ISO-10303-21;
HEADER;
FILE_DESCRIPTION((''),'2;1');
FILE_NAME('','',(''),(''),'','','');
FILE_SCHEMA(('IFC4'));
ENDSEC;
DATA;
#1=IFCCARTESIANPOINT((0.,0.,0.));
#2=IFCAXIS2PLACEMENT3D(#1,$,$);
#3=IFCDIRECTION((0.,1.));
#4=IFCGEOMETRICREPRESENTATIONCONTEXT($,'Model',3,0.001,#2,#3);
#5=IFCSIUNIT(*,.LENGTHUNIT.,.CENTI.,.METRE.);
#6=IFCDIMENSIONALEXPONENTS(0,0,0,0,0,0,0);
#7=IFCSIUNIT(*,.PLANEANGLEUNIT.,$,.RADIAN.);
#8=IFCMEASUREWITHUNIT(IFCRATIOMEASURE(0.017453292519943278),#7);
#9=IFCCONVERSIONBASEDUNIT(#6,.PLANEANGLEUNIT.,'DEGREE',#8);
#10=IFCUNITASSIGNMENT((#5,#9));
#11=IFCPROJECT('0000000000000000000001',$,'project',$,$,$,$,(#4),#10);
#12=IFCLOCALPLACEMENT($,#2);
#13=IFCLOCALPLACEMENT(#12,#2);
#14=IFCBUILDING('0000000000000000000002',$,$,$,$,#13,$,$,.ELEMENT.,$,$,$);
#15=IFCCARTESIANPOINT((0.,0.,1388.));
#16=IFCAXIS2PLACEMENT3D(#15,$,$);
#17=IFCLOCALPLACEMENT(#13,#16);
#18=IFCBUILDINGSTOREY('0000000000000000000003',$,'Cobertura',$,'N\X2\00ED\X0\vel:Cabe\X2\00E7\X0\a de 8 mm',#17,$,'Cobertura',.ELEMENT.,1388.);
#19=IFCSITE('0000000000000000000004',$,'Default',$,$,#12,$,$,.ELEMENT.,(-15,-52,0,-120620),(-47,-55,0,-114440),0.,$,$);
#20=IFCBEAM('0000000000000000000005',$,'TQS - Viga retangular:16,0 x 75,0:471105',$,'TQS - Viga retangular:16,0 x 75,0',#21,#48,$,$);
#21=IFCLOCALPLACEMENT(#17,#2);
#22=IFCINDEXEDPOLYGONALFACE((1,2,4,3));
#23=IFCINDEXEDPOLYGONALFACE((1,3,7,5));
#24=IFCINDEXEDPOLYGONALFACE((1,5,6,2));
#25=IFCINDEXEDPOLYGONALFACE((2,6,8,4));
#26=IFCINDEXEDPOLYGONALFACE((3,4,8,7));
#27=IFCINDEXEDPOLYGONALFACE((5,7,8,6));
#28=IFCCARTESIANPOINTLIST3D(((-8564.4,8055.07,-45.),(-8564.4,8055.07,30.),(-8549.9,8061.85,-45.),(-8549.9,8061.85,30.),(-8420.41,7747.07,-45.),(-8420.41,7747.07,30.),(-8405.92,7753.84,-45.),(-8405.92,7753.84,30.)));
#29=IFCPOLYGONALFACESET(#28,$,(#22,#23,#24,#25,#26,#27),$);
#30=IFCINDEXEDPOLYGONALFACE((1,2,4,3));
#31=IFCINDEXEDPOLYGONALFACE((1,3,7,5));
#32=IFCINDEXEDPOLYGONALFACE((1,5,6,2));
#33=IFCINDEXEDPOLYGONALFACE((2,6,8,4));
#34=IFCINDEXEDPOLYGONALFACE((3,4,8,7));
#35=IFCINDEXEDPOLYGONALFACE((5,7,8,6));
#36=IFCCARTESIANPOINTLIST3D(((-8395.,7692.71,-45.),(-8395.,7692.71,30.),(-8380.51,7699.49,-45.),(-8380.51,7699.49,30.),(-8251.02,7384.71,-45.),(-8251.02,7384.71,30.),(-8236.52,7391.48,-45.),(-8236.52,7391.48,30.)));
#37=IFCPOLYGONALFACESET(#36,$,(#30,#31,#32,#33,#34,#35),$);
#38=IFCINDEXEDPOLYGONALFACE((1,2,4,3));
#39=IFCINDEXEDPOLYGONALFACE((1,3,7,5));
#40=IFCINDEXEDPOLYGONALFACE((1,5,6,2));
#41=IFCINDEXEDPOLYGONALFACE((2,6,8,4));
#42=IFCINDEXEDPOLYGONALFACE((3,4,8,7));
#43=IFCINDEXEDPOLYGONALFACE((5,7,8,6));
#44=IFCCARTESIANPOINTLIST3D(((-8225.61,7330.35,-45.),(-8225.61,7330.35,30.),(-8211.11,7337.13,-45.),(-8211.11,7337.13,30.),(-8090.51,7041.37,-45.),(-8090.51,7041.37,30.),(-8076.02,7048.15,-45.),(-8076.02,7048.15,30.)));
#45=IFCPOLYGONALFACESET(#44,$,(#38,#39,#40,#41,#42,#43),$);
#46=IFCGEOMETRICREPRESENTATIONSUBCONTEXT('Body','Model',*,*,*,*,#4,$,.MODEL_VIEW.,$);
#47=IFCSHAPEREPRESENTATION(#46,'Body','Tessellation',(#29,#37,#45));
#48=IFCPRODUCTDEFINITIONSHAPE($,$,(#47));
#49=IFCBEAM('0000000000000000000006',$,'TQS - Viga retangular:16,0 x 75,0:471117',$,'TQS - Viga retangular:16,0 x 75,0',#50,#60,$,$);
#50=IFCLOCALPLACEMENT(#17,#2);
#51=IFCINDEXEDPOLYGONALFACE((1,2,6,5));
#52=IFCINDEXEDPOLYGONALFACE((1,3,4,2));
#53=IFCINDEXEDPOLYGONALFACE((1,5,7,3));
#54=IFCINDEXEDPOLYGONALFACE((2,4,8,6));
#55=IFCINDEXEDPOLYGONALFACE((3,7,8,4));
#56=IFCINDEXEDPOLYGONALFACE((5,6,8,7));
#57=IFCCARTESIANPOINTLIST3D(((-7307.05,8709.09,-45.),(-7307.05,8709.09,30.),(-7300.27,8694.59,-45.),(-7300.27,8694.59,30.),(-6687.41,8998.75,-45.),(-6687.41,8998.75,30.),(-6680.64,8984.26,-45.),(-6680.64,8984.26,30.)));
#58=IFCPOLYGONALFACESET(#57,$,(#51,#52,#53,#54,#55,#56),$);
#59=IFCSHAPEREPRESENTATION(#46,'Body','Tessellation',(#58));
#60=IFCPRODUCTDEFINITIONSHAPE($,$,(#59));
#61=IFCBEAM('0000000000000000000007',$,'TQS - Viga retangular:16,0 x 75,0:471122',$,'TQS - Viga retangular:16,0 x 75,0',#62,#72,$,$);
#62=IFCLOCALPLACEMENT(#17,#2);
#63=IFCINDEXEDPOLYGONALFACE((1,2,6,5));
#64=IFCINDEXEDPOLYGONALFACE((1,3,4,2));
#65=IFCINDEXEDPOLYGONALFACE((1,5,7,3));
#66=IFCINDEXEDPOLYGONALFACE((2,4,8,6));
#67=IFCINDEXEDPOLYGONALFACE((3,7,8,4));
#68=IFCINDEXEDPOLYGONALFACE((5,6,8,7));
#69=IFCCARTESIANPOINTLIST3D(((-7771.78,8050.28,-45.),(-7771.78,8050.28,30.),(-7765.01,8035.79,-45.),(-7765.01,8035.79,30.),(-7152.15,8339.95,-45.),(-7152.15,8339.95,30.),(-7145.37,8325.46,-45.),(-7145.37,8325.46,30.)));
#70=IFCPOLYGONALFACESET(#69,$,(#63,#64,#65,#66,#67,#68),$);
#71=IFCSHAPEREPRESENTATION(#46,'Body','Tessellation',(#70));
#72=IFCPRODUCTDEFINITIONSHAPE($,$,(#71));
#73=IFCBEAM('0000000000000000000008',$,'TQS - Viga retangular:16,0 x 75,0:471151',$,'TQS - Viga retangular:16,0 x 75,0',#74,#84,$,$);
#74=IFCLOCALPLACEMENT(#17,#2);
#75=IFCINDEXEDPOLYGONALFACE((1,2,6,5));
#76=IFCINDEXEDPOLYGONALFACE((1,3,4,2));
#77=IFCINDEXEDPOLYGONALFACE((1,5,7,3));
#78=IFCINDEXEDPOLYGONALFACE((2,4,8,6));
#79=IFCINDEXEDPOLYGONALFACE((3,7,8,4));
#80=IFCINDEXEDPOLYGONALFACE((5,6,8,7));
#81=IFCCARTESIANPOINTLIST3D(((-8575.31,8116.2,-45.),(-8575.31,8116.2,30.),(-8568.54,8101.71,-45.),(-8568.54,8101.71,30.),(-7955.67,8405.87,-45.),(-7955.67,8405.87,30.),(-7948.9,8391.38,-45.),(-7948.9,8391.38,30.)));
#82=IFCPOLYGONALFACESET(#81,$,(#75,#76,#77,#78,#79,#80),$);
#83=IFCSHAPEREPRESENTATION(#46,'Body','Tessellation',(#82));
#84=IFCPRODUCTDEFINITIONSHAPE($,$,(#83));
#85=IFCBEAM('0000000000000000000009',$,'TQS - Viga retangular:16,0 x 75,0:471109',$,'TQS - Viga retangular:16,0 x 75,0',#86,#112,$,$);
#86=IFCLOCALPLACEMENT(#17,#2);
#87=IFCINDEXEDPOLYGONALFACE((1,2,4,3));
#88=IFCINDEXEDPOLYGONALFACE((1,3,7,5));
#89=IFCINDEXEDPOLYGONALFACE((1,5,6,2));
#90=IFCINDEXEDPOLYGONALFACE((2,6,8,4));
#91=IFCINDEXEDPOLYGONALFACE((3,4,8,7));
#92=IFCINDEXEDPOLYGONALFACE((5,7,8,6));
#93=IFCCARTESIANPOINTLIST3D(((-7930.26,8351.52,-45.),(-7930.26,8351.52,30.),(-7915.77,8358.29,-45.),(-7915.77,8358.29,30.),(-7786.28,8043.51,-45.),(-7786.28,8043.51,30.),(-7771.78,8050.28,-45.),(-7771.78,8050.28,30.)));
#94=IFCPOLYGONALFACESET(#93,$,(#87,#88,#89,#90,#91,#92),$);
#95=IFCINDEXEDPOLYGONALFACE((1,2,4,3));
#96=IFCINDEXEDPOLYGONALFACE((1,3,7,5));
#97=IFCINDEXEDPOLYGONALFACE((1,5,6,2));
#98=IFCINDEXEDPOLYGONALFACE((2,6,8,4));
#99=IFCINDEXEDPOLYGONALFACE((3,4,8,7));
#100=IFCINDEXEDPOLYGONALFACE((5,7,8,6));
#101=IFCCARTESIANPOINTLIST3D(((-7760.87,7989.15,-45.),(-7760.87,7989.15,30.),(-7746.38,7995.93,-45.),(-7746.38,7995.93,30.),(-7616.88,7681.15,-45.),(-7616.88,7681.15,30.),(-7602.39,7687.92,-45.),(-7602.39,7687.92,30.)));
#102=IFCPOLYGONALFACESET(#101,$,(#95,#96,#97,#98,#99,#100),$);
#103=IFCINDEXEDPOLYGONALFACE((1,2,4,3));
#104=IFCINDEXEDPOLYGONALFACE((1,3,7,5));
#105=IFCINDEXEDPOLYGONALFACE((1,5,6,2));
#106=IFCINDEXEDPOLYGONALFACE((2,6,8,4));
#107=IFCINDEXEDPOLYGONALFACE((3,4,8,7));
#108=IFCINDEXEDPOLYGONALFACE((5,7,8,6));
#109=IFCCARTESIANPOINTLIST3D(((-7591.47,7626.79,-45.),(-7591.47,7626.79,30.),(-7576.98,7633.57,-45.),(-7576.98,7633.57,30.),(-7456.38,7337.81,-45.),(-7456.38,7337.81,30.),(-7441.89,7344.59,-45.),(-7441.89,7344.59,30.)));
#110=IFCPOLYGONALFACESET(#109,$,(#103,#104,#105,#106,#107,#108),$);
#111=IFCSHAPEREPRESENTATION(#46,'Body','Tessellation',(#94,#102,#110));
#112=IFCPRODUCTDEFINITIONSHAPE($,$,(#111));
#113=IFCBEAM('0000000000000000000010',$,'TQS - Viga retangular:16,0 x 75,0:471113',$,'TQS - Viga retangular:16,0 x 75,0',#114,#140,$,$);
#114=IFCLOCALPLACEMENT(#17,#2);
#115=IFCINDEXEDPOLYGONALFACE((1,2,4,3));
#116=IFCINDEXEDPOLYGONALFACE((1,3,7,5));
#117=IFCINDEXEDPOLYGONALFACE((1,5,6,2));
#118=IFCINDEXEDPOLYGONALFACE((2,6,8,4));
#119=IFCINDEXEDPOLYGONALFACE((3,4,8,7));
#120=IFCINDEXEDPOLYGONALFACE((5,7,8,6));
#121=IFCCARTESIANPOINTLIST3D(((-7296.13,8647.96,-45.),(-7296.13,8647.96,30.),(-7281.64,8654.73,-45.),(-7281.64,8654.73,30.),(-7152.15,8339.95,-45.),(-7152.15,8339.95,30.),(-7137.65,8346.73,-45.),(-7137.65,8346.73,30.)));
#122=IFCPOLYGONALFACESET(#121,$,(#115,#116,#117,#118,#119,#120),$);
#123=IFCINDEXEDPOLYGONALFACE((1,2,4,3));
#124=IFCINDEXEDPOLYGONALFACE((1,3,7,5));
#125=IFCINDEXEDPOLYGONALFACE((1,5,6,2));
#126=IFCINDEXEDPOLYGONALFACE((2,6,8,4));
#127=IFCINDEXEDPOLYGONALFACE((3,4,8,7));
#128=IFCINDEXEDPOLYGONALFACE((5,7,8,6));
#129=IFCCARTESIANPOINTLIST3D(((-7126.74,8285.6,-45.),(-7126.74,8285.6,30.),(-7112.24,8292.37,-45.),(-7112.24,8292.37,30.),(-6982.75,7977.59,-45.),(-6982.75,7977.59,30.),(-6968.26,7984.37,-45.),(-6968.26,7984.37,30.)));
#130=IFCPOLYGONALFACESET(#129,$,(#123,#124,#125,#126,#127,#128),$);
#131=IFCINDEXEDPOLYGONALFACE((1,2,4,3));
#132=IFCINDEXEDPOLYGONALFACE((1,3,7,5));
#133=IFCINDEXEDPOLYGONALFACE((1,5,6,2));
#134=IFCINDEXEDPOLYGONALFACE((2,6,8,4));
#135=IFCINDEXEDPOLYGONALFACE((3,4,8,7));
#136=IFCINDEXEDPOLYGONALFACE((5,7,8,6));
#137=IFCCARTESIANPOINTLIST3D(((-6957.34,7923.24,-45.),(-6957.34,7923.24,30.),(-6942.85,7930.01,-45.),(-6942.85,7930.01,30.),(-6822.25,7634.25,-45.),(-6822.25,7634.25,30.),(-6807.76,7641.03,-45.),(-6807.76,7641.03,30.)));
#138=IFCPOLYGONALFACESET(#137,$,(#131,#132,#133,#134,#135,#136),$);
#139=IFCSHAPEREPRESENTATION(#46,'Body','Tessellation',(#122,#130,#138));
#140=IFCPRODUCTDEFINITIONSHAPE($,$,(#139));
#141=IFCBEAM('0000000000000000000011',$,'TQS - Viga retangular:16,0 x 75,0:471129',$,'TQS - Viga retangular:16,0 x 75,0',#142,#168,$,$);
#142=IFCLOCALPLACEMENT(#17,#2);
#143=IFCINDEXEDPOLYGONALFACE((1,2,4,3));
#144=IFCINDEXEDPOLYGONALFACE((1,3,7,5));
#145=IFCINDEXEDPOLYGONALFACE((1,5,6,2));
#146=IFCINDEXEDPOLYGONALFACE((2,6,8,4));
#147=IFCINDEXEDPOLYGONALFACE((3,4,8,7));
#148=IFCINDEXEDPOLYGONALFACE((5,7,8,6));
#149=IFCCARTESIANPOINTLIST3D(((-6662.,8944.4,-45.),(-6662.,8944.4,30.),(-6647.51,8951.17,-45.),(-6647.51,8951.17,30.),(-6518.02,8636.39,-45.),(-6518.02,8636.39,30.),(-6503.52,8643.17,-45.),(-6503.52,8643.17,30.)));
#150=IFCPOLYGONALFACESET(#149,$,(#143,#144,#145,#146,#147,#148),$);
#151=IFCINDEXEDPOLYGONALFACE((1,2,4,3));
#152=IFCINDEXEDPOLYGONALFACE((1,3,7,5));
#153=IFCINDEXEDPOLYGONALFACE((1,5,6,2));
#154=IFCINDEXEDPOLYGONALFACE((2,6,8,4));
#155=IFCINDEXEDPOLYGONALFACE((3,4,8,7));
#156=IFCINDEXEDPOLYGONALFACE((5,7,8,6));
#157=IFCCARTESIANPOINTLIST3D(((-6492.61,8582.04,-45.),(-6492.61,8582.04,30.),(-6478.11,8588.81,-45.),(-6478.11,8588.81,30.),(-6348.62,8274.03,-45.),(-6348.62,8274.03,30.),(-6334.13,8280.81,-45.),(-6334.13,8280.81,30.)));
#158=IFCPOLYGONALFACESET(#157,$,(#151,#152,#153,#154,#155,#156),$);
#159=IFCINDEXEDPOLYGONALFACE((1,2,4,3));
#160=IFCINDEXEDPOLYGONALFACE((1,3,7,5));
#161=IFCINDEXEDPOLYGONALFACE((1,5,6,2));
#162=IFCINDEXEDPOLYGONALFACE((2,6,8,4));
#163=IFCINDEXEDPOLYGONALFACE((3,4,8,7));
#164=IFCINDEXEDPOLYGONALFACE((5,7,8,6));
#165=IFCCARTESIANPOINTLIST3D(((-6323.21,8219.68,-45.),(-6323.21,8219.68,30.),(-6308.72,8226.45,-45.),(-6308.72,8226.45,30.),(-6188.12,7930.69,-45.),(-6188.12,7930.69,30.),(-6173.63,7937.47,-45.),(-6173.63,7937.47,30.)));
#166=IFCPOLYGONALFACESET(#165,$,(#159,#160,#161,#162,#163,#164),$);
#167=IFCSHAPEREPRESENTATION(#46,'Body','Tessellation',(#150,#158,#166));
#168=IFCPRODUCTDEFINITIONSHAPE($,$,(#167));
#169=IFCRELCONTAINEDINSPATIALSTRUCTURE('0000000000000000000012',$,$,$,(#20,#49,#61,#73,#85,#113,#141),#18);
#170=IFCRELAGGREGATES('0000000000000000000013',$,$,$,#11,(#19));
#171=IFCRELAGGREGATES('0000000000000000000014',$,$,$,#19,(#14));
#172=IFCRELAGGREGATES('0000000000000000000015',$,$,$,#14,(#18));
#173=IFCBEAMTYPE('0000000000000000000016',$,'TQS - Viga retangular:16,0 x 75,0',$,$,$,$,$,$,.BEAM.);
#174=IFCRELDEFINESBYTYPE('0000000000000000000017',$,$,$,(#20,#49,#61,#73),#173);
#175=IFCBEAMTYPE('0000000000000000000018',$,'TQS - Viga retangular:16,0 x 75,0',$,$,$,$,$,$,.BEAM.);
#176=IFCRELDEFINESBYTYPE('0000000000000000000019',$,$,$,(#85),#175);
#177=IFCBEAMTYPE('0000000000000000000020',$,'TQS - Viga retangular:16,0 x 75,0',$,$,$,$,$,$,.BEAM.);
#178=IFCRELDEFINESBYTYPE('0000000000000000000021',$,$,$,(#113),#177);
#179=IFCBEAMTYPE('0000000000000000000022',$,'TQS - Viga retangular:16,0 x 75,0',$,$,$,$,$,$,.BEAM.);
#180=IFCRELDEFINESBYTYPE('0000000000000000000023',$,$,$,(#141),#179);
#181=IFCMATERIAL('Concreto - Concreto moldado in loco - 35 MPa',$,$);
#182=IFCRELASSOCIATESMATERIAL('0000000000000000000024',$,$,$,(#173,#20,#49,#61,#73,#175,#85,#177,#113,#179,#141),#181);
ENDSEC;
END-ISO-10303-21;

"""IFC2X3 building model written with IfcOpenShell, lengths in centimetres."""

from ifc_helpers import new_model, entity, si_unit, converted_unit, direction, frame, frame_2d, origin, place, context, subcontext, project, spatial, rectangle, extrude, source, transform, mapped, material, type_object, type_shapes, element, save


model = new_model("IFC2X3")

# Units and contexts
model_context = context("Model", 3, precision=0.001, world=origin(), true_north=direction((0.0, 1.0)))
body_context = subcontext(model_context, "Body", "Model", "MODEL_VIEW")
ifc_project = project(units=[si_unit("LENGTHUNIT", "METRE", prefix="CENTI"), converted_unit("PLANEANGLEUNIT", "DEGREE", entity("IfcRatioMeasure", 0.017453292519943278), si_unit("PLANEANGLEUNIT", "RADIAN"), dimensions=[0, 0, 0, 0, 0, 0, 0])], contexts=[model_context])

# Site, building, storey
site_placement = place(None, origin())
site = spatial("IfcSite", under=ifc_project, at=site_placement, Name="Default", CompositionType="ELEMENT", RefLatitude=(-15, -52, 0, -120620), RefLongitude=(-47, -55, 0, -114440), RefElevation=0.0)
building_placement = place(site_placement, origin())
building = spatial("IfcBuilding", under=site, at=building_placement, CompositionType="ELEMENT")
storey_placement = place(building_placement, frame((0.0, 0.0, 1388.0)))
storey = spatial("IfcBuildingStorey", under=building, at=storey_placement, Name="Cobertura", ObjectType="Nível:Cabeça de 8 mm", LongName="Cobertura", CompositionType="ELEMENT", Elevation=1388.0)

# Beams
ifc_material = material(Name="Concreto - Concreto moldado in loco - 35 MPa")
beam_type_1 = type_object("IfcBeamType", Name="TQS - Viga retangular:16,0 x 75,0", PredefinedType="BEAM", material=ifc_material)
shared_shape_1 = source(origin(), body_context, "Body", "SweptSolid", [
    extrude(rectangle(XDim=75.0, YDim=16.0, at=frame_2d((0.0, 0.0), x_axis=(1.0, 0.0))), frame((-8413.16, 7750.46, 1380.5), z_axis=(-0.423488, 0.905902, 0.0), x_axis=(0.0, 0.0, 1.0)), (0.0, 0.0, 1.0), 340.0),
    extrude(rectangle(XDim=75.0, YDim=16.0, at=frame_2d((0.0, 0.0), x_axis=(1.0, 0.0))), frame((-8243.77, 7388.09, 1380.5), z_axis=(-0.423488, 0.905902, 0.0), x_axis=(0.0, 0.0, 1.0)), (0.0, 0.0, 1.0), 340.0),
    extrude(rectangle(XDim=75.0, YDim=16.0, at=frame_2d((0.0, 0.0), x_axis=(1.0, 0.0))), frame((-8083.27, 7044.76, 1380.5), z_axis=(-0.423488, 0.905902, 0.0), x_axis=(0.0, 0.0, 1.0)), (0.0, 0.0, 1.0), 319.0),
])
type_shapes(beam_type_1, [shared_shape_1])
beam_1_placement = place(storey_placement, frame((0.0, 0.0, -1388.0)))
element("IfcBeam", 1, at=beam_1_placement, inside=storey, type_object=beam_type_1, material=ifc_material, Name="TQS - Viga retangular:16,0 x 75,0:471105", ObjectType="TQS - Viga retangular:16,0 x 75,0", context=body_context, shape_type="MappedRepresentation", body=[
    mapped(shared_shape_1, transform((0.0, 0.0, 0.0), scale=1.0)),
])
beam_2_placement = place(storey_placement, frame((-7310.91, 8698.45, 30.0), z_axis=(0.0, 0.0, 1.0), x_axis=(0.905902, 0.423488, 0.0)))
element("IfcBeam", 2, at=beam_2_placement, inside=storey, type_object=beam_type_1, material=ifc_material, Name="TQS - Viga retangular:16,0 x 75,0:471117", ObjectType="TQS - Viga retangular:16,0 x 75,0", context=body_context, shape_type="SweptSolid", body=[
    extrude(rectangle(XDim=75.0, YDim=16.0, at=frame_2d((0.0, 0.0), x_axis=(1.0, 0.0))), frame((8.0, 0.0, -37.5), z_axis=(1.0, 0.0, 0.0), x_axis=(0.0, 0.0, -1.0)), (0.0, 0.0, 1.0), 684.0),
])
beam_3_placement = place(storey_placement, frame((-7775.64, 8039.65, 30.0), z_axis=(0.0, 0.0, 1.0), x_axis=(0.905902, 0.423488, 0.0)))
element("IfcBeam", 3, at=beam_3_placement, inside=storey, type_object=beam_type_1, material=ifc_material, Name="TQS - Viga retangular:16,0 x 75,0:471122", ObjectType="TQS - Viga retangular:16,0 x 75,0", context=body_context, shape_type="SweptSolid", body=[
    extrude(rectangle(XDim=75.0, YDim=16.0, at=frame_2d((0.0, 0.0), x_axis=(1.0, 0.0))), frame((8.0, 0.0, -37.5), z_axis=(1.0, 0.0, 0.0), x_axis=(0.0, 0.0, -1.0)), (0.0, 0.0, 1.0), 684.0),
])
beam_4_placement = place(storey_placement, frame((-8579.17, 8105.57, 30.0), z_axis=(0.0, 0.0, 1.0), x_axis=(0.905902, 0.423488, 0.0)))
element("IfcBeam", 4, at=beam_4_placement, inside=storey, type_object=beam_type_1, material=ifc_material, Name="TQS - Viga retangular:16,0 x 75,0:471151", ObjectType="TQS - Viga retangular:16,0 x 75,0", context=body_context, shape_type="SweptSolid", body=[
    extrude(rectangle(XDim=75.0, YDim=16.0, at=frame_2d((0.0, 0.0), x_axis=(1.0, 0.0))), frame((8.0, 0.0, -37.5), z_axis=(1.0, 0.0, 0.0), x_axis=(0.0, 0.0, -1.0)), (0.0, 0.0, 1.0), 684.0),
])
beam_type_2 = type_object("IfcBeamType", Name="TQS - Viga retangular:16,0 x 75,0", PredefinedType="BEAM", material=ifc_material)
shared_shape_2 = source(origin(), body_context, "Body", "SweptSolid", [
    extrude(rectangle(XDim=75.0, YDim=16.0, at=frame_2d((0.0, 0.0), x_axis=(1.0, 0.0))), frame((-7779.03, 8046.9, 1380.5), z_axis=(-0.423488, 0.905902, 0.0), x_axis=(0.0, 0.0, 1.0)), (0.0, 0.0, 1.0), 340.0),
    extrude(rectangle(XDim=75.0, YDim=16.0, at=frame_2d((0.0, 0.0), x_axis=(1.0, 0.0))), frame((-7609.64, 7684.54, 1380.5), z_axis=(-0.423488, 0.905902, 0.0), x_axis=(0.0, 0.0, 1.0)), (0.0, 0.0, 1.0), 340.0),
    extrude(rectangle(XDim=75.0, YDim=16.0, at=frame_2d((0.0, 0.0), x_axis=(1.0, 0.0))), frame((-7449.13, 7341.2, 1380.5), z_axis=(-0.423488, 0.905902, 0.0), x_axis=(0.0, 0.0, 1.0)), (0.0, 0.0, 1.0), 319.0),
])
type_shapes(beam_type_2, [shared_shape_2])
beam_5_placement = place(storey_placement, frame((0.0, 0.0, -1388.0)))
element("IfcBeam", 5, at=beam_5_placement, inside=storey, type_object=beam_type_2, material=ifc_material, Name="TQS - Viga retangular:16,0 x 75,0:471109", ObjectType="TQS - Viga retangular:16,0 x 75,0", context=body_context, shape_type="MappedRepresentation", body=[
    mapped(shared_shape_2, transform((0.0, 0.0, 0.0), scale=1.0)),
])
beam_type_3 = type_object("IfcBeamType", Name="TQS - Viga retangular:16,0 x 75,0", PredefinedType="BEAM", material=ifc_material)
shared_shape_3 = source(origin(), body_context, "Body", "SweptSolid", [
    extrude(rectangle(XDim=75.0, YDim=16.0, at=frame_2d((0.0, 0.0), x_axis=(1.0, 0.0))), frame((-7144.9, 8343.34, 1380.5), z_axis=(-0.423488, 0.905902, 0.0), x_axis=(0.0, 0.0, 1.0)), (0.0, 0.0, 1.0), 340.0),
    extrude(rectangle(XDim=75.0, YDim=16.0, at=frame_2d((0.0, 0.0), x_axis=(1.0, 0.0))), frame((-6975.51, 7980.98, 1380.5), z_axis=(-0.423488, 0.905902, 0.0), x_axis=(0.0, 0.0, 1.0)), (0.0, 0.0, 1.0), 340.0),
    extrude(rectangle(XDim=75.0, YDim=16.0, at=frame_2d((0.0, 0.0), x_axis=(1.0, 0.0))), frame((-6815.0, 7637.64, 1380.5), z_axis=(-0.423488, 0.905902, 0.0), x_axis=(0.0, 0.0, 1.0)), (0.0, 0.0, 1.0), 319.0),
])
type_shapes(beam_type_3, [shared_shape_3])
beam_6_placement = place(storey_placement, frame((0.0, 0.0, -1388.0)))
element("IfcBeam", 6, at=beam_6_placement, inside=storey, type_object=beam_type_3, material=ifc_material, Name="TQS - Viga retangular:16,0 x 75,0:471113", ObjectType="TQS - Viga retangular:16,0 x 75,0", context=body_context, shape_type="MappedRepresentation", body=[
    mapped(shared_shape_3, transform((0.0, 0.0, 0.0), scale=1.0)),
])
beam_type_4 = type_object("IfcBeamType", Name="TQS - Viga retangular:16,0 x 75,0", PredefinedType="BEAM", material=ifc_material)
shared_shape_4 = source(origin(), body_context, "Body", "SweptSolid", [
    extrude(rectangle(XDim=75.0, YDim=16.0, at=frame_2d((0.0, 0.0), x_axis=(1.0, 0.0))), frame((-6510.77, 8639.78, 1380.5), z_axis=(-0.423488, 0.905902, 0.0), x_axis=(0.0, 0.0, 1.0)), (0.0, 0.0, 1.0), 340.0),
    extrude(rectangle(XDim=75.0, YDim=16.0, at=frame_2d((0.0, 0.0), x_axis=(1.0, 0.0))), frame((-6341.37, 8277.42, 1380.5), z_axis=(-0.423488, 0.905902, 0.0), x_axis=(0.0, 0.0, 1.0)), (0.0, 0.0, 1.0), 340.0),
    extrude(rectangle(XDim=75.0, YDim=16.0, at=frame_2d((0.0, 0.0), x_axis=(1.0, 0.0))), frame((-6180.87, 7934.08, 1380.5), z_axis=(-0.423488, 0.905902, 0.0), x_axis=(0.0, 0.0, 1.0)), (0.0, 0.0, 1.0), 319.0),
])
type_shapes(beam_type_4, [shared_shape_4])
beam_7_placement = place(storey_placement, frame((0.0, 0.0, -1388.0)))
element("IfcBeam", 7, at=beam_7_placement, inside=storey, type_object=beam_type_4, material=ifc_material, Name="TQS - Viga retangular:16,0 x 75,0:471129", ObjectType="TQS - Viga retangular:16,0 x 75,0", context=body_context, shape_type="MappedRepresentation", body=[
    mapped(shared_shape_4, transform((0.0, 0.0, 0.0), scale=1.0)),
])

save(model, "model.ifc")
